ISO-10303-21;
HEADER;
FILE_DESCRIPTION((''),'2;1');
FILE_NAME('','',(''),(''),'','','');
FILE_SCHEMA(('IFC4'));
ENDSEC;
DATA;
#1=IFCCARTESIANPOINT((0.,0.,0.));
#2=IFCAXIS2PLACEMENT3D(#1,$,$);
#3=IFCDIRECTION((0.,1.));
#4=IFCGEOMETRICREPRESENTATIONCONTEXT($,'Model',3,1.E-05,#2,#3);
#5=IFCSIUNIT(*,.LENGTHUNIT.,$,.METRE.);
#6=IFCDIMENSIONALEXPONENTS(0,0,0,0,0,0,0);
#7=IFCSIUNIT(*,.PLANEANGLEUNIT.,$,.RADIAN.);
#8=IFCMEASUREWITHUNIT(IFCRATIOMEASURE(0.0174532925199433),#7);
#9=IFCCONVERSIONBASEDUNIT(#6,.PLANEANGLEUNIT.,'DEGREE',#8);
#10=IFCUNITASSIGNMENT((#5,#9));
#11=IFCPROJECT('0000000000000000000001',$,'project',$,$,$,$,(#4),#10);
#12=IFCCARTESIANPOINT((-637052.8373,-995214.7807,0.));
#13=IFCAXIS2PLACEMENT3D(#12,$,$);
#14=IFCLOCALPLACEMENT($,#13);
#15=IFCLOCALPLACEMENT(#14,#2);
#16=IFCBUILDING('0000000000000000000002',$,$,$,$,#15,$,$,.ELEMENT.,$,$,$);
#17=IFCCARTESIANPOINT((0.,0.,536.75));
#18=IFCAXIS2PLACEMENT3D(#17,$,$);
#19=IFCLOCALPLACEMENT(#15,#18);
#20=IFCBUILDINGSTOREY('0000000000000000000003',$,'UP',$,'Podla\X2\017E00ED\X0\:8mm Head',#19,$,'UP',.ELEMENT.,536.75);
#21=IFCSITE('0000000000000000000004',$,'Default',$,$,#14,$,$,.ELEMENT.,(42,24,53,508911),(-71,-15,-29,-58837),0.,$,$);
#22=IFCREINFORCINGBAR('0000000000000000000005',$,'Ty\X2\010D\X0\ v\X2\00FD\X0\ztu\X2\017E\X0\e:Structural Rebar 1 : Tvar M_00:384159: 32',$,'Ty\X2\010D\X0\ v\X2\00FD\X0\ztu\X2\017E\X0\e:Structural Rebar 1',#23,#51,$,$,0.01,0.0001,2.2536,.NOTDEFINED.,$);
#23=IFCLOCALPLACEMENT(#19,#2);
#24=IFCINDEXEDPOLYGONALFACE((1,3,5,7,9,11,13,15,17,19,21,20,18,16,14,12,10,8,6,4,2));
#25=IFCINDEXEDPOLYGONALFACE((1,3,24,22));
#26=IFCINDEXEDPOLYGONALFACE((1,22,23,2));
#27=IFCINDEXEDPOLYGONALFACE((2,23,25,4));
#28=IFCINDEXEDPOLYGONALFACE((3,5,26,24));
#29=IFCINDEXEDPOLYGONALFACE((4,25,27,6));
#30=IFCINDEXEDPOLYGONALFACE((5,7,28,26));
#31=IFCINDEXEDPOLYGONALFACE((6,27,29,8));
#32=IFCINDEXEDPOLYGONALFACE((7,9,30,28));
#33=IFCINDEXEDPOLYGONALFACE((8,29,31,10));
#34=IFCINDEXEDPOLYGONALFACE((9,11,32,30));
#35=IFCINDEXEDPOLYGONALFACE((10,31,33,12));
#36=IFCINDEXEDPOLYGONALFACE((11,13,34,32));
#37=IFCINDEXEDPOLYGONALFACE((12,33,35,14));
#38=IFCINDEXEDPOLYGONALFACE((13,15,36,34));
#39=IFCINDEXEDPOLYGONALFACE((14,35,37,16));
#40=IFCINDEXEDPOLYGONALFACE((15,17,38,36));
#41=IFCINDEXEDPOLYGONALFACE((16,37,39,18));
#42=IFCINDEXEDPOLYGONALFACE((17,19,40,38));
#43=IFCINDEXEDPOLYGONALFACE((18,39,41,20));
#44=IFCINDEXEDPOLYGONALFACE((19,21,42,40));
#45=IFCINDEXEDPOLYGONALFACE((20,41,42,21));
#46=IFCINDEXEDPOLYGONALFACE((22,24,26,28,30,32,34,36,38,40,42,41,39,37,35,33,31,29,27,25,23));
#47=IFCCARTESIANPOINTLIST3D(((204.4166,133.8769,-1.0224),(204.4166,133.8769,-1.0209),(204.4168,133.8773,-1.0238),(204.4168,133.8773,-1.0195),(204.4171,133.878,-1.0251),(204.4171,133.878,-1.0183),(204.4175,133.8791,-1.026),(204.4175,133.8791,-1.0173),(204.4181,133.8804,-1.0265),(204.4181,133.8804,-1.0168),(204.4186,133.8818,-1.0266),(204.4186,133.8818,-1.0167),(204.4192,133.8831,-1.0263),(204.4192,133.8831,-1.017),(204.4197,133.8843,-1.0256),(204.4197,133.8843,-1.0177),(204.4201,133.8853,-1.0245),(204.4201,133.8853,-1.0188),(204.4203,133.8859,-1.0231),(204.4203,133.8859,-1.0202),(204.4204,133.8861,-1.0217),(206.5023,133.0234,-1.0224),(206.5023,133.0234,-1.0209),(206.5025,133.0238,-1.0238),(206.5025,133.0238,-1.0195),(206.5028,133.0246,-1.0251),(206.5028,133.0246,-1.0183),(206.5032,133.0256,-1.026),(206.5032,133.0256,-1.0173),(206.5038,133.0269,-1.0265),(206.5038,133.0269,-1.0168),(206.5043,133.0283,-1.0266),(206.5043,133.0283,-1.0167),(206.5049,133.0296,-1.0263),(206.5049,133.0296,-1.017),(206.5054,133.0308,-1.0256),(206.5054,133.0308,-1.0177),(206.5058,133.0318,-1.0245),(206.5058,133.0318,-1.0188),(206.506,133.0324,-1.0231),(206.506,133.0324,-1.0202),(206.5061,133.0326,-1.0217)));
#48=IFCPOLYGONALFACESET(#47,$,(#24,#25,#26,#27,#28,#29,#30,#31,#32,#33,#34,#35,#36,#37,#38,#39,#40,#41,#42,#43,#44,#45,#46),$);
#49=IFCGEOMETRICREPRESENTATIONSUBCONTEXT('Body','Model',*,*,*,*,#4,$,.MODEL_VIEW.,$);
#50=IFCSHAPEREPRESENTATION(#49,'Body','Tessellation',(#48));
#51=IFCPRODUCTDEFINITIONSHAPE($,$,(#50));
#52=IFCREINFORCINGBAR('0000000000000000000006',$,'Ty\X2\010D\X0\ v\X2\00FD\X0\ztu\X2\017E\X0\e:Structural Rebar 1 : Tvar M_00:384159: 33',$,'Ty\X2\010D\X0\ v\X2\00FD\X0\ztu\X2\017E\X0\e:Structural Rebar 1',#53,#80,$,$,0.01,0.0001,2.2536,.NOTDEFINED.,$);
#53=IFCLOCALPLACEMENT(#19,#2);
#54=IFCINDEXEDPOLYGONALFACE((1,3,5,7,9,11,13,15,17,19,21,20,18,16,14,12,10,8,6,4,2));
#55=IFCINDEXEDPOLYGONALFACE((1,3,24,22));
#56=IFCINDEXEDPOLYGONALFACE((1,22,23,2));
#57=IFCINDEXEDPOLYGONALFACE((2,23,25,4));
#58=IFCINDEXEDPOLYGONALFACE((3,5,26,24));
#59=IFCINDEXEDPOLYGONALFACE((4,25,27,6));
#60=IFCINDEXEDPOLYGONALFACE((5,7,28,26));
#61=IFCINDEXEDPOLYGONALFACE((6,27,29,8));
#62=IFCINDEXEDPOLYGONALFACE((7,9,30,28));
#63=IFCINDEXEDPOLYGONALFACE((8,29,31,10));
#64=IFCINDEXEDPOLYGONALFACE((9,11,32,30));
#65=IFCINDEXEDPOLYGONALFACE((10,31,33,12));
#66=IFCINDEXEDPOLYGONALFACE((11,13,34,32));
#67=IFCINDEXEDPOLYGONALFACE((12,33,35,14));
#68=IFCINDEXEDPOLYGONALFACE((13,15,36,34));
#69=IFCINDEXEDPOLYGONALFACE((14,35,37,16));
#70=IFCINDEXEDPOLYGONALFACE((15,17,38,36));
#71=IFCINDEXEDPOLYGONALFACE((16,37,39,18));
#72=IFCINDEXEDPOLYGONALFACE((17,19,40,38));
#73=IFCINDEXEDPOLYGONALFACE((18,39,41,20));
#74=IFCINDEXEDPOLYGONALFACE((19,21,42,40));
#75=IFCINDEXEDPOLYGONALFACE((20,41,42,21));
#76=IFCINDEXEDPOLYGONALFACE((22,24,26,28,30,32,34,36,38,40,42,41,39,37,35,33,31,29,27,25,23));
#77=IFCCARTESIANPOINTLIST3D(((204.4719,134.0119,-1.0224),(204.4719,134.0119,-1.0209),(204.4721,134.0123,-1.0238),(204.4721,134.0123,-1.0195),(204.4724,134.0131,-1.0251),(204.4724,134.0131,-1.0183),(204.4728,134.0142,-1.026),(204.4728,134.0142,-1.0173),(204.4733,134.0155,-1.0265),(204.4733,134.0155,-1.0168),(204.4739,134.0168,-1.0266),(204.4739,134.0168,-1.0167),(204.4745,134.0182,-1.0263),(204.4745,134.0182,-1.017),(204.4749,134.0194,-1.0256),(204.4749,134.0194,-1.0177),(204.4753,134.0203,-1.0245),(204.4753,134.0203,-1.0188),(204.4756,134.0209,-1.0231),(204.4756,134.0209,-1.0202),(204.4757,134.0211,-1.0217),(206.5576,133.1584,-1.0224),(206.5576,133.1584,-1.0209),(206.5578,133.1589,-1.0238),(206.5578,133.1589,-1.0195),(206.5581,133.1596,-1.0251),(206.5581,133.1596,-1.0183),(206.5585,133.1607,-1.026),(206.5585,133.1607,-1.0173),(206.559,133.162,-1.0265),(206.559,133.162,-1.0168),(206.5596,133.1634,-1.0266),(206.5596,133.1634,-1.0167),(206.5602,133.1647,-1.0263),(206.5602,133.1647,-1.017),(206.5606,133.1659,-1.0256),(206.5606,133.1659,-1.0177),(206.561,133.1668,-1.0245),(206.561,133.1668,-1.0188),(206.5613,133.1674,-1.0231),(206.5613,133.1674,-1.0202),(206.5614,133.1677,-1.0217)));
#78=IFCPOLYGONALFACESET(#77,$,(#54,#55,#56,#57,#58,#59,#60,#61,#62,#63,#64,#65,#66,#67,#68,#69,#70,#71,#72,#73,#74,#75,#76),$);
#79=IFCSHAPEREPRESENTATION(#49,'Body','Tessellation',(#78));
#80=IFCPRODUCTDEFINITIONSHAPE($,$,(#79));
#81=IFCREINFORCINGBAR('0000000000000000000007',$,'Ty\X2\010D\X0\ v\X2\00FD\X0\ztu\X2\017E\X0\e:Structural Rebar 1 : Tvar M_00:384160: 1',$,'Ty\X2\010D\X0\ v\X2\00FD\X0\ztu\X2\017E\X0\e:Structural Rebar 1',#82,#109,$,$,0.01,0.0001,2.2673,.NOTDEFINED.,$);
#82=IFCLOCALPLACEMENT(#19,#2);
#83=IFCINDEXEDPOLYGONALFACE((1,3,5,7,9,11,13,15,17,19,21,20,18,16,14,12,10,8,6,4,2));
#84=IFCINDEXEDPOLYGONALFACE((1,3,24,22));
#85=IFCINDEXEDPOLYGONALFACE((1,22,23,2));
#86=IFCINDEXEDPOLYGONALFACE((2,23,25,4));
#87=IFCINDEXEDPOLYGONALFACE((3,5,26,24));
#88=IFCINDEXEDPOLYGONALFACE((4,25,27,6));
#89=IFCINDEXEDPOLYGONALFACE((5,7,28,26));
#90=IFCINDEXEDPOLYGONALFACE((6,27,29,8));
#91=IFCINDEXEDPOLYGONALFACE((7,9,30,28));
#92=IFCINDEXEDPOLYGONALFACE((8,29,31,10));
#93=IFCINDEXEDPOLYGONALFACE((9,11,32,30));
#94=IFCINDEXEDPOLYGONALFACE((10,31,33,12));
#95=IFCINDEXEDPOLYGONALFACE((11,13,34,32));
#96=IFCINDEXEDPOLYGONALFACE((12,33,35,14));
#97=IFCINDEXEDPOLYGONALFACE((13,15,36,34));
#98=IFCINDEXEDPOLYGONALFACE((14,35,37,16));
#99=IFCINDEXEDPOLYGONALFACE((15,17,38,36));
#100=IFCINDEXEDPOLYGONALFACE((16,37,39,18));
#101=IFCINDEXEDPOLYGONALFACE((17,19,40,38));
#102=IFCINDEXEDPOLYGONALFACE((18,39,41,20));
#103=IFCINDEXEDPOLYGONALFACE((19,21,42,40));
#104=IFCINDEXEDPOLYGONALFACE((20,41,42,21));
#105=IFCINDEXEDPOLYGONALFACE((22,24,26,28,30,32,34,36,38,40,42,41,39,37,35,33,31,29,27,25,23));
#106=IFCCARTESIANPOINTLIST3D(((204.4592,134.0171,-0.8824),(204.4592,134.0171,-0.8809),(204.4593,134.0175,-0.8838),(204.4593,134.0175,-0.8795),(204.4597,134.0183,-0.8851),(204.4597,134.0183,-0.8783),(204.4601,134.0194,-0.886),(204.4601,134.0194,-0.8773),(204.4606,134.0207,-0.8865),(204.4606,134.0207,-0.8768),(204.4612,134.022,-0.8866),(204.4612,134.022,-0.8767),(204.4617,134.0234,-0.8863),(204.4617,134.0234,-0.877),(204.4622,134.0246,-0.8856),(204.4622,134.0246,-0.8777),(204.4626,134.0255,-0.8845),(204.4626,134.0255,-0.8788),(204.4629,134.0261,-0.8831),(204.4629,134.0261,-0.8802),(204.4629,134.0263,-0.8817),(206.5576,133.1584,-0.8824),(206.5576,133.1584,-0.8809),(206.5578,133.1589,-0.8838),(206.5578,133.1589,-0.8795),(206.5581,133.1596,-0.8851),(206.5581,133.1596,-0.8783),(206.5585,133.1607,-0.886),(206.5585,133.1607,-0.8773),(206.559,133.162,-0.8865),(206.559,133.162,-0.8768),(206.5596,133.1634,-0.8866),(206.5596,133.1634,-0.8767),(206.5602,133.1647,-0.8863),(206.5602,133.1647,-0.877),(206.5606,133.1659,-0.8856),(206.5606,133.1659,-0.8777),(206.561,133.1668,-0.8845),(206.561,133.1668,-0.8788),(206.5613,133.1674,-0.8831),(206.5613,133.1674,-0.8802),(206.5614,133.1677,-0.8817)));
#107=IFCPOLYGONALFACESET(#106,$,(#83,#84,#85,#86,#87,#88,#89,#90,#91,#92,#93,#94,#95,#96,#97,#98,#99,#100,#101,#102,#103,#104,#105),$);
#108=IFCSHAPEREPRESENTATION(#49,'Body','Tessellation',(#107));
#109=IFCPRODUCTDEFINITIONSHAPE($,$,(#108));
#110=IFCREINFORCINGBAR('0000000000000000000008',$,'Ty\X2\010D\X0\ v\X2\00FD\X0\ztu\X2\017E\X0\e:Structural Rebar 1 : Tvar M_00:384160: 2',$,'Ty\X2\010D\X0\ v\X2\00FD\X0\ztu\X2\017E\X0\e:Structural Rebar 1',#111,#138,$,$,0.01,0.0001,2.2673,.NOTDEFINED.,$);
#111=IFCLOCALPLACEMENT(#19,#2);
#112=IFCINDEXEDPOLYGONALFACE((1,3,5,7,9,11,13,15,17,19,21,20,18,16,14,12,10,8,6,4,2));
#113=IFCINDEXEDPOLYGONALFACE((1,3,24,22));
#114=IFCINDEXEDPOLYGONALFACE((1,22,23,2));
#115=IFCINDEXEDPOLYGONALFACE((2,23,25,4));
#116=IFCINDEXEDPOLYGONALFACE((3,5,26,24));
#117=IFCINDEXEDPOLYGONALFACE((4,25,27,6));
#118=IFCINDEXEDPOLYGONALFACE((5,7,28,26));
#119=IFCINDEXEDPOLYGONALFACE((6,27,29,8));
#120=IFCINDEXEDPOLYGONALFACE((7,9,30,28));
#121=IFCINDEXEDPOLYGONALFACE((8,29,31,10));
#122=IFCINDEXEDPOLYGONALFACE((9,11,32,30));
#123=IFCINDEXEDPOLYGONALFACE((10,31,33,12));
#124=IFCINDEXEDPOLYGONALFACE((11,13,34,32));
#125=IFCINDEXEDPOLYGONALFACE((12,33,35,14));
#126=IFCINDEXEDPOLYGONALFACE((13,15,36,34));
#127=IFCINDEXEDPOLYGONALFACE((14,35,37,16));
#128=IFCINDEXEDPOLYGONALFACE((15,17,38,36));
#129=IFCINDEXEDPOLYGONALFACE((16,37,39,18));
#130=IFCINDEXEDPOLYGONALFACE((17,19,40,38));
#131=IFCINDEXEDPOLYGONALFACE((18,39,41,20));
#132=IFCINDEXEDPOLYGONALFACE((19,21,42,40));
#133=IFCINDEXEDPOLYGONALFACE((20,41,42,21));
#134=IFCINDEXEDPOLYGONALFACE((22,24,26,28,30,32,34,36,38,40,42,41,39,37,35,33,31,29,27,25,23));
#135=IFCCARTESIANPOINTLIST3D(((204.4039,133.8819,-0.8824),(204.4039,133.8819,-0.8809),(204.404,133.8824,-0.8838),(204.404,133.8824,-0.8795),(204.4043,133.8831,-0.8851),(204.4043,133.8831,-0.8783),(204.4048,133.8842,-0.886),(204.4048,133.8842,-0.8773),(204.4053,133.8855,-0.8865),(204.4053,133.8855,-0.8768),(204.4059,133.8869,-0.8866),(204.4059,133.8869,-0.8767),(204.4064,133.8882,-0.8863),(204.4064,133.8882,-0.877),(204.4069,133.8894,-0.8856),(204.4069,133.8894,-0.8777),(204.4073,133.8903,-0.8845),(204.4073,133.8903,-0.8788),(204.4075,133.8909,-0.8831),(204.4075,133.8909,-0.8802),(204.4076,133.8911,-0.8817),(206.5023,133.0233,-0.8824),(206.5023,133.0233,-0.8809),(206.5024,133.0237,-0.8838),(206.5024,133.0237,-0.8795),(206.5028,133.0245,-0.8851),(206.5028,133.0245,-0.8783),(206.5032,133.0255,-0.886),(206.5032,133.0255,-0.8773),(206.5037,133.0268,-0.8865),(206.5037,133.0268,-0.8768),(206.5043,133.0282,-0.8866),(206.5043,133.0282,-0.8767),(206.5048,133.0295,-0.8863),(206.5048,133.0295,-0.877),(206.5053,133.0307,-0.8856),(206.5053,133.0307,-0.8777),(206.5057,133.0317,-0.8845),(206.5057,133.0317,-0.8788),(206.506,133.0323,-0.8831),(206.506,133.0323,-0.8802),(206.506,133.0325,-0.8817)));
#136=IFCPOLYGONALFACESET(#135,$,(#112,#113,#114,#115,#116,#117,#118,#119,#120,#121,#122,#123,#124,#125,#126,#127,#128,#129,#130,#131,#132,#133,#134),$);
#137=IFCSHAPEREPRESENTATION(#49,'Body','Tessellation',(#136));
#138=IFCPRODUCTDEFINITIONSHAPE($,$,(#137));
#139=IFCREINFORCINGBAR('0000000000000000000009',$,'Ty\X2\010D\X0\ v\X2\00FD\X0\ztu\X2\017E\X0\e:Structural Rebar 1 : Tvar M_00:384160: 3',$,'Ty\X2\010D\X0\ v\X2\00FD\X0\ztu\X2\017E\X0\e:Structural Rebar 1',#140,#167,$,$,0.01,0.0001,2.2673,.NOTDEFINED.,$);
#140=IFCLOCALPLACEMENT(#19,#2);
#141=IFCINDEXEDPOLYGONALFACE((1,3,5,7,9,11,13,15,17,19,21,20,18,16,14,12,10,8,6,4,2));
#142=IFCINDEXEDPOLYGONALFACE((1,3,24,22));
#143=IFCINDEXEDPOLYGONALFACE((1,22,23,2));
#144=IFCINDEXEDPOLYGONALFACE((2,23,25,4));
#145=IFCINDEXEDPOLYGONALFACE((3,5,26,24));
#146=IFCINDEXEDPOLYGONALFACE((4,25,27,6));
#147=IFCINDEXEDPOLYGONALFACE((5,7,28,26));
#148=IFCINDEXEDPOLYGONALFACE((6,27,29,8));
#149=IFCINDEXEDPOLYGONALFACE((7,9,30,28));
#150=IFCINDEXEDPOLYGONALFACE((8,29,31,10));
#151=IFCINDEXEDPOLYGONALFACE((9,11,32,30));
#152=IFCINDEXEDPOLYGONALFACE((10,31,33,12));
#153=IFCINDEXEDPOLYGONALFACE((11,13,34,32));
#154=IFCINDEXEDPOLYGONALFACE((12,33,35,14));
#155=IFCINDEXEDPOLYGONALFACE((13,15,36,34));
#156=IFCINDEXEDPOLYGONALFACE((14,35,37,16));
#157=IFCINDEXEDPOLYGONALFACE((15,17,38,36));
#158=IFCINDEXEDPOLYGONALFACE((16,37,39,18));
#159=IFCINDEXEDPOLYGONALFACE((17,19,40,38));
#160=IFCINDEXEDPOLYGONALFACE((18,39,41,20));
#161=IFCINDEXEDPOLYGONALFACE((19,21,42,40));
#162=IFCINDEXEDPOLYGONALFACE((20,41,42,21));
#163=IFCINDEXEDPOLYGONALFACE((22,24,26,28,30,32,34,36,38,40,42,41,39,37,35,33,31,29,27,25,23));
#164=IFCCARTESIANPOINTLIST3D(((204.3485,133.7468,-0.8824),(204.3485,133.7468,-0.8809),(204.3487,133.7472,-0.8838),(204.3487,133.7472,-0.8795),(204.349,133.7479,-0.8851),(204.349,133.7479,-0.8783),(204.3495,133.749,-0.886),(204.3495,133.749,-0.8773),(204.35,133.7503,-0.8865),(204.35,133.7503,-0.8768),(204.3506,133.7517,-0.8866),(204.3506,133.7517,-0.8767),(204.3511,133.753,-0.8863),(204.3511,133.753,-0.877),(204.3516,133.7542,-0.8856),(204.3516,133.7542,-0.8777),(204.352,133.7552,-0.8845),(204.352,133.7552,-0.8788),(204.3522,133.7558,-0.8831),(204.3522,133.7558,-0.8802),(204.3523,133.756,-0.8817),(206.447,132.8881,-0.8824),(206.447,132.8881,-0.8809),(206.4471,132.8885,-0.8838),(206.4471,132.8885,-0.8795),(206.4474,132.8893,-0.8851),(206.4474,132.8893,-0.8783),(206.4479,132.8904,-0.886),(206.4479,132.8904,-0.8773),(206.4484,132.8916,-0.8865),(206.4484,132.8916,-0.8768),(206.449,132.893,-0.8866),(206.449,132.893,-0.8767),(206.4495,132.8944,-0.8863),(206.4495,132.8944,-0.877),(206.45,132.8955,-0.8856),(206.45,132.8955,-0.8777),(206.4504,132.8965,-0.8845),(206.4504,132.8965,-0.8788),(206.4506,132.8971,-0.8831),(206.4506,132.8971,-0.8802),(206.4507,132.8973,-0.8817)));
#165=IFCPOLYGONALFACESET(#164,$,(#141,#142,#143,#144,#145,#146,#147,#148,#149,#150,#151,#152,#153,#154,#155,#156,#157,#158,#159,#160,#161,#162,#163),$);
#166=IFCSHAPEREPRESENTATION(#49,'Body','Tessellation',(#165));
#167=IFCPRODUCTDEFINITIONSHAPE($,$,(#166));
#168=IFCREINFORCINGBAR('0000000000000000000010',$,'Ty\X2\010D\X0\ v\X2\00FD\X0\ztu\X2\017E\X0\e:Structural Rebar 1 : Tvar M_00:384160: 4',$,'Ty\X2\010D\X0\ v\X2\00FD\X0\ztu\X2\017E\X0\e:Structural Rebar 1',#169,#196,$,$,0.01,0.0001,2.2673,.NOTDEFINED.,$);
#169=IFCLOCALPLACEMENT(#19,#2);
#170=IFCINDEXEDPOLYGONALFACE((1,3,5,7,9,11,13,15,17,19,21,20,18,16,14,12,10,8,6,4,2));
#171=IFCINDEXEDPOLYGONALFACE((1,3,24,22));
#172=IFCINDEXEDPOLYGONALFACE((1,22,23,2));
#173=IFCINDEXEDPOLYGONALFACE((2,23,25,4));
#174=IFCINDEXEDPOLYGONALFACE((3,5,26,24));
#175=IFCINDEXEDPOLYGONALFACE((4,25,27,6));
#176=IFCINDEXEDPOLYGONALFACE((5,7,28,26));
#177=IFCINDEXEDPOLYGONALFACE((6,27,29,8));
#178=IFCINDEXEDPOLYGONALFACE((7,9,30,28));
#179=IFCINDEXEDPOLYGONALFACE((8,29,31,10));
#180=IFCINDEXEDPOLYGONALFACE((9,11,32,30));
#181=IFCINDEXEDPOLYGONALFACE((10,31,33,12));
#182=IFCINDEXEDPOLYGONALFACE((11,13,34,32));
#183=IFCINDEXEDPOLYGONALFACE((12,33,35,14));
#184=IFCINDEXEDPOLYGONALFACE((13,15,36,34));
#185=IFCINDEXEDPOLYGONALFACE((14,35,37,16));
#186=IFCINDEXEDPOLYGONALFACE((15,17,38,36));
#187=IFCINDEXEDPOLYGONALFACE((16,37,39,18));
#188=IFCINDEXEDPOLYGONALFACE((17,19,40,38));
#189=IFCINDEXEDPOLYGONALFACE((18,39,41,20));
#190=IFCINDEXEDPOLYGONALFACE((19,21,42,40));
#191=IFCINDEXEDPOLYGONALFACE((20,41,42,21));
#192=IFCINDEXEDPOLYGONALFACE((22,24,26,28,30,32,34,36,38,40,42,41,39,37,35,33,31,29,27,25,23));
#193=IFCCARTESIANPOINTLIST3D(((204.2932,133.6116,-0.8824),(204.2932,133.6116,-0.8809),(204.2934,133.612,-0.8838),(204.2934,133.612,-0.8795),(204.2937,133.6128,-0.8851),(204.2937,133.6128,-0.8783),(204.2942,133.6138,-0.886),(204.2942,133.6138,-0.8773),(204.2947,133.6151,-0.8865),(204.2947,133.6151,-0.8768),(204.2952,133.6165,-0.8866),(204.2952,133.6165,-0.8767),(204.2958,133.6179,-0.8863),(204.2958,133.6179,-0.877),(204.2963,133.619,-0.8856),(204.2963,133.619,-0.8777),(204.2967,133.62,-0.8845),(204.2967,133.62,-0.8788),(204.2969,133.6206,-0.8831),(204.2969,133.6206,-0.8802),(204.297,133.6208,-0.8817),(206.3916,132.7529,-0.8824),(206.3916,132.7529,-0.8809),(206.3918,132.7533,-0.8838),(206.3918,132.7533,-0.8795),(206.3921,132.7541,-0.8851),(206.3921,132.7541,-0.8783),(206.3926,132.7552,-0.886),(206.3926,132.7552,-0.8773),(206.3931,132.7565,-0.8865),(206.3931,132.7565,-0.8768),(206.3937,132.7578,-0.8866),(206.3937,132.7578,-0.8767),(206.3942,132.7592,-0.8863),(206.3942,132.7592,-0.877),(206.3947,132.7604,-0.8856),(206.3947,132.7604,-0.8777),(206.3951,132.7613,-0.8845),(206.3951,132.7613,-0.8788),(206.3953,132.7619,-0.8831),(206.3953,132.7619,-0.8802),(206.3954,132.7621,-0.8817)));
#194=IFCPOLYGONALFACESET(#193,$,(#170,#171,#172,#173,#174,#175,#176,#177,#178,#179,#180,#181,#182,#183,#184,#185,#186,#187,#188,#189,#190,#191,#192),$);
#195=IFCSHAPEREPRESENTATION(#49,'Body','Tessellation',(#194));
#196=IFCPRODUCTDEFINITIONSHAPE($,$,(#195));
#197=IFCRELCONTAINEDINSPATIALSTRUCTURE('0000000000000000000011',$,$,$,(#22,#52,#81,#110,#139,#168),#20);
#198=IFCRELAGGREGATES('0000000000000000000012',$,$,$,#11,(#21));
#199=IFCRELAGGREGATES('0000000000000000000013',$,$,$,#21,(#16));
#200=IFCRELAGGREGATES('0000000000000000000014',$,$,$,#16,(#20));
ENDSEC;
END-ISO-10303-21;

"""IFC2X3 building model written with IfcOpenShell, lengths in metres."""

from ifc_helpers import new_model, entity, si_unit, converted_unit, direction, frame, origin, place, context, subcontext, project, spatial, element, save


model = new_model("IFC2X3")

# Units and contexts
model_context = context("Model", 3, precision=1e-05, world=origin(), true_north=direction((0.0, 1.0)))
body_context = subcontext(model_context, "Body", "Model", "MODEL_VIEW")
ifc_project = project(units=[si_unit("LENGTHUNIT", "METRE"), converted_unit("PLANEANGLEUNIT", "DEGREE", entity("IfcRatioMeasure", 0.0174532925199433), si_unit("PLANEANGLEUNIT", "RADIAN"), dimensions=[0, 0, 0, 0, 0, 0, 0])], contexts=[model_context])

# Site, building, storey
site_placement = place(None, frame((-637052.8373, -995214.7807, 0.0)))
site = spatial("IfcSite", under=ifc_project, at=site_placement, Name="Default", CompositionType="ELEMENT", RefLatitude=(42, 24, 53, 508911), RefLongitude=(-71, -15, -29, -58837), RefElevation=0.0)
building_placement = place(site_placement, origin())
building = spatial("IfcBuilding", under=site, at=building_placement, CompositionType="ELEMENT")
storey_placement = place(building_placement, frame((0.0, 0.0, 536.75)))
storey = spatial("IfcBuildingStorey", under=building, at=storey_placement, Name="UP", ObjectType="Podlaží:8mm Head", LongName="UP", CompositionType="ELEMENT", Elevation=536.75)

# Reinforcing bars
reinforcing_bar_1_placement = place(storey_placement, origin())
element("IfcReinforcingBar", 1, at=reinforcing_bar_1_placement, inside=storey, Name="Tyč výztuže:Structural Rebar 1 : Tvar M_00:384159: 32", ObjectType="Tyč výztuže:Structural Rebar 1", BarLength=2.2536, BarRole="NOTDEFINED", CrossSectionArea=0.0001, NominalDiameter=0.01, context=body_context, shape_type="AdvancedSweptSolid", body=[
    entity("IfcSweptDiskSolid", entity("IfcCompositeCurve", [entity("IfcCompositeCurveSegment", "CONTINUOUS", True, entity("IfcPolyline", [entity("IfcCartesianPoint", [-206.5042, -133.028, 1.0217]), entity("IfcCartesianPoint", [-204.4185, -133.8814, 1.0217])]))], False), 0.005, None, 0.0, 1.0),
])
reinforcing_bar_2_placement = place(storey_placement, origin())
element("IfcReinforcingBar", 2, at=reinforcing_bar_2_placement, inside=storey, Name="Tyč výztuže:Structural Rebar 1 : Tvar M_00:384159: 33", ObjectType="Tyč výztuže:Structural Rebar 1", BarLength=2.2536, BarRole="NOTDEFINED", CrossSectionArea=0.0001, NominalDiameter=0.01, context=body_context, shape_type="AdvancedSweptSolid", body=[
    entity("IfcSweptDiskSolid", entity("IfcCompositeCurve", [entity("IfcCompositeCurveSegment", "CONTINUOUS", True, entity("IfcPolyline", [entity("IfcCartesianPoint", [-206.5595, -133.163, 1.0217]), entity("IfcCartesianPoint", [-204.4738, -134.0165, 1.0217])]))], False), 0.005, None, 0.0, 1.0),
])
reinforcing_bar_3_placement = place(storey_placement, origin())
element("IfcReinforcingBar", 3, at=reinforcing_bar_3_placement, inside=storey, Name="Tyč výztuže:Structural Rebar 1 : Tvar M_00:384160: 1", ObjectType="Tyč výztuže:Structural Rebar 1", BarLength=2.2673, BarRole="NOTDEFINED", CrossSectionArea=0.0001, NominalDiameter=0.01, context=body_context, shape_type="AdvancedSweptSolid", body=[
    entity("IfcSweptDiskSolid", entity("IfcCompositeCurve", [entity("IfcCompositeCurveSegment", "CONTINUOUS", True, entity("IfcPolyline", [entity("IfcCartesianPoint", [-206.5595, -133.163, 0.8817]), entity("IfcCartesianPoint", [-204.4611, -134.0217, 0.8817])]))], False), 0.005, None, 0.0, 1.0),
])
reinforcing_bar_4_placement = place(storey_placement, origin())
element("IfcReinforcingBar", 4, at=reinforcing_bar_4_placement, inside=storey, Name="Tyč výztuže:Structural Rebar 1 : Tvar M_00:384160: 2", ObjectType="Tyč výztuže:Structural Rebar 1", BarLength=2.2673, BarRole="NOTDEFINED", CrossSectionArea=0.0001, NominalDiameter=0.01, context=body_context, shape_type="AdvancedSweptSolid", body=[
    entity("IfcSweptDiskSolid", entity("IfcCompositeCurve", [entity("IfcCompositeCurveSegment", "CONTINUOUS", True, entity("IfcPolyline", [entity("IfcCartesianPoint", [-206.5041, -133.0278, 0.8817]), entity("IfcCartesianPoint", [-204.4057, -133.8865, 0.8817])]))], False), 0.005, None, 0.0, 1.0),
])
reinforcing_bar_5_placement = place(storey_placement, origin())
element("IfcReinforcingBar", 5, at=reinforcing_bar_5_placement, inside=storey, Name="Tyč výztuže:Structural Rebar 1 : Tvar M_00:384160: 3", ObjectType="Tyč výztuže:Structural Rebar 1", BarLength=2.2673, BarRole="NOTDEFINED", CrossSectionArea=0.0001, NominalDiameter=0.01, context=body_context, shape_type="AdvancedSweptSolid", body=[
    entity("IfcSweptDiskSolid", entity("IfcCompositeCurve", [entity("IfcCompositeCurveSegment", "CONTINUOUS", True, entity("IfcPolyline", [entity("IfcCartesianPoint", [-206.4488, -132.8927, 0.8817]), entity("IfcCartesianPoint", [-204.3504, -133.7513, 0.8817])]))], False), 0.005, None, 0.0, 1.0),
])
reinforcing_bar_6_placement = place(storey_placement, origin())
element("IfcReinforcingBar", 6, at=reinforcing_bar_6_placement, inside=storey, Name="Tyč výztuže:Structural Rebar 1 : Tvar M_00:384160: 4", ObjectType="Tyč výztuže:Structural Rebar 1", BarLength=2.2673, BarRole="NOTDEFINED", CrossSectionArea=0.0001, NominalDiameter=0.01, context=body_context, shape_type="AdvancedSweptSolid", body=[
    entity("IfcSweptDiskSolid", entity("IfcCompositeCurve", [entity("IfcCompositeCurveSegment", "CONTINUOUS", True, entity("IfcPolyline", [entity("IfcCartesianPoint", [-206.3935, -132.7575, 0.8817]), entity("IfcCartesianPoint", [-204.2951, -133.6162, 0.8817])]))], False), 0.005, None, 0.0, 1.0),
])

save(model, "model.ifc")
